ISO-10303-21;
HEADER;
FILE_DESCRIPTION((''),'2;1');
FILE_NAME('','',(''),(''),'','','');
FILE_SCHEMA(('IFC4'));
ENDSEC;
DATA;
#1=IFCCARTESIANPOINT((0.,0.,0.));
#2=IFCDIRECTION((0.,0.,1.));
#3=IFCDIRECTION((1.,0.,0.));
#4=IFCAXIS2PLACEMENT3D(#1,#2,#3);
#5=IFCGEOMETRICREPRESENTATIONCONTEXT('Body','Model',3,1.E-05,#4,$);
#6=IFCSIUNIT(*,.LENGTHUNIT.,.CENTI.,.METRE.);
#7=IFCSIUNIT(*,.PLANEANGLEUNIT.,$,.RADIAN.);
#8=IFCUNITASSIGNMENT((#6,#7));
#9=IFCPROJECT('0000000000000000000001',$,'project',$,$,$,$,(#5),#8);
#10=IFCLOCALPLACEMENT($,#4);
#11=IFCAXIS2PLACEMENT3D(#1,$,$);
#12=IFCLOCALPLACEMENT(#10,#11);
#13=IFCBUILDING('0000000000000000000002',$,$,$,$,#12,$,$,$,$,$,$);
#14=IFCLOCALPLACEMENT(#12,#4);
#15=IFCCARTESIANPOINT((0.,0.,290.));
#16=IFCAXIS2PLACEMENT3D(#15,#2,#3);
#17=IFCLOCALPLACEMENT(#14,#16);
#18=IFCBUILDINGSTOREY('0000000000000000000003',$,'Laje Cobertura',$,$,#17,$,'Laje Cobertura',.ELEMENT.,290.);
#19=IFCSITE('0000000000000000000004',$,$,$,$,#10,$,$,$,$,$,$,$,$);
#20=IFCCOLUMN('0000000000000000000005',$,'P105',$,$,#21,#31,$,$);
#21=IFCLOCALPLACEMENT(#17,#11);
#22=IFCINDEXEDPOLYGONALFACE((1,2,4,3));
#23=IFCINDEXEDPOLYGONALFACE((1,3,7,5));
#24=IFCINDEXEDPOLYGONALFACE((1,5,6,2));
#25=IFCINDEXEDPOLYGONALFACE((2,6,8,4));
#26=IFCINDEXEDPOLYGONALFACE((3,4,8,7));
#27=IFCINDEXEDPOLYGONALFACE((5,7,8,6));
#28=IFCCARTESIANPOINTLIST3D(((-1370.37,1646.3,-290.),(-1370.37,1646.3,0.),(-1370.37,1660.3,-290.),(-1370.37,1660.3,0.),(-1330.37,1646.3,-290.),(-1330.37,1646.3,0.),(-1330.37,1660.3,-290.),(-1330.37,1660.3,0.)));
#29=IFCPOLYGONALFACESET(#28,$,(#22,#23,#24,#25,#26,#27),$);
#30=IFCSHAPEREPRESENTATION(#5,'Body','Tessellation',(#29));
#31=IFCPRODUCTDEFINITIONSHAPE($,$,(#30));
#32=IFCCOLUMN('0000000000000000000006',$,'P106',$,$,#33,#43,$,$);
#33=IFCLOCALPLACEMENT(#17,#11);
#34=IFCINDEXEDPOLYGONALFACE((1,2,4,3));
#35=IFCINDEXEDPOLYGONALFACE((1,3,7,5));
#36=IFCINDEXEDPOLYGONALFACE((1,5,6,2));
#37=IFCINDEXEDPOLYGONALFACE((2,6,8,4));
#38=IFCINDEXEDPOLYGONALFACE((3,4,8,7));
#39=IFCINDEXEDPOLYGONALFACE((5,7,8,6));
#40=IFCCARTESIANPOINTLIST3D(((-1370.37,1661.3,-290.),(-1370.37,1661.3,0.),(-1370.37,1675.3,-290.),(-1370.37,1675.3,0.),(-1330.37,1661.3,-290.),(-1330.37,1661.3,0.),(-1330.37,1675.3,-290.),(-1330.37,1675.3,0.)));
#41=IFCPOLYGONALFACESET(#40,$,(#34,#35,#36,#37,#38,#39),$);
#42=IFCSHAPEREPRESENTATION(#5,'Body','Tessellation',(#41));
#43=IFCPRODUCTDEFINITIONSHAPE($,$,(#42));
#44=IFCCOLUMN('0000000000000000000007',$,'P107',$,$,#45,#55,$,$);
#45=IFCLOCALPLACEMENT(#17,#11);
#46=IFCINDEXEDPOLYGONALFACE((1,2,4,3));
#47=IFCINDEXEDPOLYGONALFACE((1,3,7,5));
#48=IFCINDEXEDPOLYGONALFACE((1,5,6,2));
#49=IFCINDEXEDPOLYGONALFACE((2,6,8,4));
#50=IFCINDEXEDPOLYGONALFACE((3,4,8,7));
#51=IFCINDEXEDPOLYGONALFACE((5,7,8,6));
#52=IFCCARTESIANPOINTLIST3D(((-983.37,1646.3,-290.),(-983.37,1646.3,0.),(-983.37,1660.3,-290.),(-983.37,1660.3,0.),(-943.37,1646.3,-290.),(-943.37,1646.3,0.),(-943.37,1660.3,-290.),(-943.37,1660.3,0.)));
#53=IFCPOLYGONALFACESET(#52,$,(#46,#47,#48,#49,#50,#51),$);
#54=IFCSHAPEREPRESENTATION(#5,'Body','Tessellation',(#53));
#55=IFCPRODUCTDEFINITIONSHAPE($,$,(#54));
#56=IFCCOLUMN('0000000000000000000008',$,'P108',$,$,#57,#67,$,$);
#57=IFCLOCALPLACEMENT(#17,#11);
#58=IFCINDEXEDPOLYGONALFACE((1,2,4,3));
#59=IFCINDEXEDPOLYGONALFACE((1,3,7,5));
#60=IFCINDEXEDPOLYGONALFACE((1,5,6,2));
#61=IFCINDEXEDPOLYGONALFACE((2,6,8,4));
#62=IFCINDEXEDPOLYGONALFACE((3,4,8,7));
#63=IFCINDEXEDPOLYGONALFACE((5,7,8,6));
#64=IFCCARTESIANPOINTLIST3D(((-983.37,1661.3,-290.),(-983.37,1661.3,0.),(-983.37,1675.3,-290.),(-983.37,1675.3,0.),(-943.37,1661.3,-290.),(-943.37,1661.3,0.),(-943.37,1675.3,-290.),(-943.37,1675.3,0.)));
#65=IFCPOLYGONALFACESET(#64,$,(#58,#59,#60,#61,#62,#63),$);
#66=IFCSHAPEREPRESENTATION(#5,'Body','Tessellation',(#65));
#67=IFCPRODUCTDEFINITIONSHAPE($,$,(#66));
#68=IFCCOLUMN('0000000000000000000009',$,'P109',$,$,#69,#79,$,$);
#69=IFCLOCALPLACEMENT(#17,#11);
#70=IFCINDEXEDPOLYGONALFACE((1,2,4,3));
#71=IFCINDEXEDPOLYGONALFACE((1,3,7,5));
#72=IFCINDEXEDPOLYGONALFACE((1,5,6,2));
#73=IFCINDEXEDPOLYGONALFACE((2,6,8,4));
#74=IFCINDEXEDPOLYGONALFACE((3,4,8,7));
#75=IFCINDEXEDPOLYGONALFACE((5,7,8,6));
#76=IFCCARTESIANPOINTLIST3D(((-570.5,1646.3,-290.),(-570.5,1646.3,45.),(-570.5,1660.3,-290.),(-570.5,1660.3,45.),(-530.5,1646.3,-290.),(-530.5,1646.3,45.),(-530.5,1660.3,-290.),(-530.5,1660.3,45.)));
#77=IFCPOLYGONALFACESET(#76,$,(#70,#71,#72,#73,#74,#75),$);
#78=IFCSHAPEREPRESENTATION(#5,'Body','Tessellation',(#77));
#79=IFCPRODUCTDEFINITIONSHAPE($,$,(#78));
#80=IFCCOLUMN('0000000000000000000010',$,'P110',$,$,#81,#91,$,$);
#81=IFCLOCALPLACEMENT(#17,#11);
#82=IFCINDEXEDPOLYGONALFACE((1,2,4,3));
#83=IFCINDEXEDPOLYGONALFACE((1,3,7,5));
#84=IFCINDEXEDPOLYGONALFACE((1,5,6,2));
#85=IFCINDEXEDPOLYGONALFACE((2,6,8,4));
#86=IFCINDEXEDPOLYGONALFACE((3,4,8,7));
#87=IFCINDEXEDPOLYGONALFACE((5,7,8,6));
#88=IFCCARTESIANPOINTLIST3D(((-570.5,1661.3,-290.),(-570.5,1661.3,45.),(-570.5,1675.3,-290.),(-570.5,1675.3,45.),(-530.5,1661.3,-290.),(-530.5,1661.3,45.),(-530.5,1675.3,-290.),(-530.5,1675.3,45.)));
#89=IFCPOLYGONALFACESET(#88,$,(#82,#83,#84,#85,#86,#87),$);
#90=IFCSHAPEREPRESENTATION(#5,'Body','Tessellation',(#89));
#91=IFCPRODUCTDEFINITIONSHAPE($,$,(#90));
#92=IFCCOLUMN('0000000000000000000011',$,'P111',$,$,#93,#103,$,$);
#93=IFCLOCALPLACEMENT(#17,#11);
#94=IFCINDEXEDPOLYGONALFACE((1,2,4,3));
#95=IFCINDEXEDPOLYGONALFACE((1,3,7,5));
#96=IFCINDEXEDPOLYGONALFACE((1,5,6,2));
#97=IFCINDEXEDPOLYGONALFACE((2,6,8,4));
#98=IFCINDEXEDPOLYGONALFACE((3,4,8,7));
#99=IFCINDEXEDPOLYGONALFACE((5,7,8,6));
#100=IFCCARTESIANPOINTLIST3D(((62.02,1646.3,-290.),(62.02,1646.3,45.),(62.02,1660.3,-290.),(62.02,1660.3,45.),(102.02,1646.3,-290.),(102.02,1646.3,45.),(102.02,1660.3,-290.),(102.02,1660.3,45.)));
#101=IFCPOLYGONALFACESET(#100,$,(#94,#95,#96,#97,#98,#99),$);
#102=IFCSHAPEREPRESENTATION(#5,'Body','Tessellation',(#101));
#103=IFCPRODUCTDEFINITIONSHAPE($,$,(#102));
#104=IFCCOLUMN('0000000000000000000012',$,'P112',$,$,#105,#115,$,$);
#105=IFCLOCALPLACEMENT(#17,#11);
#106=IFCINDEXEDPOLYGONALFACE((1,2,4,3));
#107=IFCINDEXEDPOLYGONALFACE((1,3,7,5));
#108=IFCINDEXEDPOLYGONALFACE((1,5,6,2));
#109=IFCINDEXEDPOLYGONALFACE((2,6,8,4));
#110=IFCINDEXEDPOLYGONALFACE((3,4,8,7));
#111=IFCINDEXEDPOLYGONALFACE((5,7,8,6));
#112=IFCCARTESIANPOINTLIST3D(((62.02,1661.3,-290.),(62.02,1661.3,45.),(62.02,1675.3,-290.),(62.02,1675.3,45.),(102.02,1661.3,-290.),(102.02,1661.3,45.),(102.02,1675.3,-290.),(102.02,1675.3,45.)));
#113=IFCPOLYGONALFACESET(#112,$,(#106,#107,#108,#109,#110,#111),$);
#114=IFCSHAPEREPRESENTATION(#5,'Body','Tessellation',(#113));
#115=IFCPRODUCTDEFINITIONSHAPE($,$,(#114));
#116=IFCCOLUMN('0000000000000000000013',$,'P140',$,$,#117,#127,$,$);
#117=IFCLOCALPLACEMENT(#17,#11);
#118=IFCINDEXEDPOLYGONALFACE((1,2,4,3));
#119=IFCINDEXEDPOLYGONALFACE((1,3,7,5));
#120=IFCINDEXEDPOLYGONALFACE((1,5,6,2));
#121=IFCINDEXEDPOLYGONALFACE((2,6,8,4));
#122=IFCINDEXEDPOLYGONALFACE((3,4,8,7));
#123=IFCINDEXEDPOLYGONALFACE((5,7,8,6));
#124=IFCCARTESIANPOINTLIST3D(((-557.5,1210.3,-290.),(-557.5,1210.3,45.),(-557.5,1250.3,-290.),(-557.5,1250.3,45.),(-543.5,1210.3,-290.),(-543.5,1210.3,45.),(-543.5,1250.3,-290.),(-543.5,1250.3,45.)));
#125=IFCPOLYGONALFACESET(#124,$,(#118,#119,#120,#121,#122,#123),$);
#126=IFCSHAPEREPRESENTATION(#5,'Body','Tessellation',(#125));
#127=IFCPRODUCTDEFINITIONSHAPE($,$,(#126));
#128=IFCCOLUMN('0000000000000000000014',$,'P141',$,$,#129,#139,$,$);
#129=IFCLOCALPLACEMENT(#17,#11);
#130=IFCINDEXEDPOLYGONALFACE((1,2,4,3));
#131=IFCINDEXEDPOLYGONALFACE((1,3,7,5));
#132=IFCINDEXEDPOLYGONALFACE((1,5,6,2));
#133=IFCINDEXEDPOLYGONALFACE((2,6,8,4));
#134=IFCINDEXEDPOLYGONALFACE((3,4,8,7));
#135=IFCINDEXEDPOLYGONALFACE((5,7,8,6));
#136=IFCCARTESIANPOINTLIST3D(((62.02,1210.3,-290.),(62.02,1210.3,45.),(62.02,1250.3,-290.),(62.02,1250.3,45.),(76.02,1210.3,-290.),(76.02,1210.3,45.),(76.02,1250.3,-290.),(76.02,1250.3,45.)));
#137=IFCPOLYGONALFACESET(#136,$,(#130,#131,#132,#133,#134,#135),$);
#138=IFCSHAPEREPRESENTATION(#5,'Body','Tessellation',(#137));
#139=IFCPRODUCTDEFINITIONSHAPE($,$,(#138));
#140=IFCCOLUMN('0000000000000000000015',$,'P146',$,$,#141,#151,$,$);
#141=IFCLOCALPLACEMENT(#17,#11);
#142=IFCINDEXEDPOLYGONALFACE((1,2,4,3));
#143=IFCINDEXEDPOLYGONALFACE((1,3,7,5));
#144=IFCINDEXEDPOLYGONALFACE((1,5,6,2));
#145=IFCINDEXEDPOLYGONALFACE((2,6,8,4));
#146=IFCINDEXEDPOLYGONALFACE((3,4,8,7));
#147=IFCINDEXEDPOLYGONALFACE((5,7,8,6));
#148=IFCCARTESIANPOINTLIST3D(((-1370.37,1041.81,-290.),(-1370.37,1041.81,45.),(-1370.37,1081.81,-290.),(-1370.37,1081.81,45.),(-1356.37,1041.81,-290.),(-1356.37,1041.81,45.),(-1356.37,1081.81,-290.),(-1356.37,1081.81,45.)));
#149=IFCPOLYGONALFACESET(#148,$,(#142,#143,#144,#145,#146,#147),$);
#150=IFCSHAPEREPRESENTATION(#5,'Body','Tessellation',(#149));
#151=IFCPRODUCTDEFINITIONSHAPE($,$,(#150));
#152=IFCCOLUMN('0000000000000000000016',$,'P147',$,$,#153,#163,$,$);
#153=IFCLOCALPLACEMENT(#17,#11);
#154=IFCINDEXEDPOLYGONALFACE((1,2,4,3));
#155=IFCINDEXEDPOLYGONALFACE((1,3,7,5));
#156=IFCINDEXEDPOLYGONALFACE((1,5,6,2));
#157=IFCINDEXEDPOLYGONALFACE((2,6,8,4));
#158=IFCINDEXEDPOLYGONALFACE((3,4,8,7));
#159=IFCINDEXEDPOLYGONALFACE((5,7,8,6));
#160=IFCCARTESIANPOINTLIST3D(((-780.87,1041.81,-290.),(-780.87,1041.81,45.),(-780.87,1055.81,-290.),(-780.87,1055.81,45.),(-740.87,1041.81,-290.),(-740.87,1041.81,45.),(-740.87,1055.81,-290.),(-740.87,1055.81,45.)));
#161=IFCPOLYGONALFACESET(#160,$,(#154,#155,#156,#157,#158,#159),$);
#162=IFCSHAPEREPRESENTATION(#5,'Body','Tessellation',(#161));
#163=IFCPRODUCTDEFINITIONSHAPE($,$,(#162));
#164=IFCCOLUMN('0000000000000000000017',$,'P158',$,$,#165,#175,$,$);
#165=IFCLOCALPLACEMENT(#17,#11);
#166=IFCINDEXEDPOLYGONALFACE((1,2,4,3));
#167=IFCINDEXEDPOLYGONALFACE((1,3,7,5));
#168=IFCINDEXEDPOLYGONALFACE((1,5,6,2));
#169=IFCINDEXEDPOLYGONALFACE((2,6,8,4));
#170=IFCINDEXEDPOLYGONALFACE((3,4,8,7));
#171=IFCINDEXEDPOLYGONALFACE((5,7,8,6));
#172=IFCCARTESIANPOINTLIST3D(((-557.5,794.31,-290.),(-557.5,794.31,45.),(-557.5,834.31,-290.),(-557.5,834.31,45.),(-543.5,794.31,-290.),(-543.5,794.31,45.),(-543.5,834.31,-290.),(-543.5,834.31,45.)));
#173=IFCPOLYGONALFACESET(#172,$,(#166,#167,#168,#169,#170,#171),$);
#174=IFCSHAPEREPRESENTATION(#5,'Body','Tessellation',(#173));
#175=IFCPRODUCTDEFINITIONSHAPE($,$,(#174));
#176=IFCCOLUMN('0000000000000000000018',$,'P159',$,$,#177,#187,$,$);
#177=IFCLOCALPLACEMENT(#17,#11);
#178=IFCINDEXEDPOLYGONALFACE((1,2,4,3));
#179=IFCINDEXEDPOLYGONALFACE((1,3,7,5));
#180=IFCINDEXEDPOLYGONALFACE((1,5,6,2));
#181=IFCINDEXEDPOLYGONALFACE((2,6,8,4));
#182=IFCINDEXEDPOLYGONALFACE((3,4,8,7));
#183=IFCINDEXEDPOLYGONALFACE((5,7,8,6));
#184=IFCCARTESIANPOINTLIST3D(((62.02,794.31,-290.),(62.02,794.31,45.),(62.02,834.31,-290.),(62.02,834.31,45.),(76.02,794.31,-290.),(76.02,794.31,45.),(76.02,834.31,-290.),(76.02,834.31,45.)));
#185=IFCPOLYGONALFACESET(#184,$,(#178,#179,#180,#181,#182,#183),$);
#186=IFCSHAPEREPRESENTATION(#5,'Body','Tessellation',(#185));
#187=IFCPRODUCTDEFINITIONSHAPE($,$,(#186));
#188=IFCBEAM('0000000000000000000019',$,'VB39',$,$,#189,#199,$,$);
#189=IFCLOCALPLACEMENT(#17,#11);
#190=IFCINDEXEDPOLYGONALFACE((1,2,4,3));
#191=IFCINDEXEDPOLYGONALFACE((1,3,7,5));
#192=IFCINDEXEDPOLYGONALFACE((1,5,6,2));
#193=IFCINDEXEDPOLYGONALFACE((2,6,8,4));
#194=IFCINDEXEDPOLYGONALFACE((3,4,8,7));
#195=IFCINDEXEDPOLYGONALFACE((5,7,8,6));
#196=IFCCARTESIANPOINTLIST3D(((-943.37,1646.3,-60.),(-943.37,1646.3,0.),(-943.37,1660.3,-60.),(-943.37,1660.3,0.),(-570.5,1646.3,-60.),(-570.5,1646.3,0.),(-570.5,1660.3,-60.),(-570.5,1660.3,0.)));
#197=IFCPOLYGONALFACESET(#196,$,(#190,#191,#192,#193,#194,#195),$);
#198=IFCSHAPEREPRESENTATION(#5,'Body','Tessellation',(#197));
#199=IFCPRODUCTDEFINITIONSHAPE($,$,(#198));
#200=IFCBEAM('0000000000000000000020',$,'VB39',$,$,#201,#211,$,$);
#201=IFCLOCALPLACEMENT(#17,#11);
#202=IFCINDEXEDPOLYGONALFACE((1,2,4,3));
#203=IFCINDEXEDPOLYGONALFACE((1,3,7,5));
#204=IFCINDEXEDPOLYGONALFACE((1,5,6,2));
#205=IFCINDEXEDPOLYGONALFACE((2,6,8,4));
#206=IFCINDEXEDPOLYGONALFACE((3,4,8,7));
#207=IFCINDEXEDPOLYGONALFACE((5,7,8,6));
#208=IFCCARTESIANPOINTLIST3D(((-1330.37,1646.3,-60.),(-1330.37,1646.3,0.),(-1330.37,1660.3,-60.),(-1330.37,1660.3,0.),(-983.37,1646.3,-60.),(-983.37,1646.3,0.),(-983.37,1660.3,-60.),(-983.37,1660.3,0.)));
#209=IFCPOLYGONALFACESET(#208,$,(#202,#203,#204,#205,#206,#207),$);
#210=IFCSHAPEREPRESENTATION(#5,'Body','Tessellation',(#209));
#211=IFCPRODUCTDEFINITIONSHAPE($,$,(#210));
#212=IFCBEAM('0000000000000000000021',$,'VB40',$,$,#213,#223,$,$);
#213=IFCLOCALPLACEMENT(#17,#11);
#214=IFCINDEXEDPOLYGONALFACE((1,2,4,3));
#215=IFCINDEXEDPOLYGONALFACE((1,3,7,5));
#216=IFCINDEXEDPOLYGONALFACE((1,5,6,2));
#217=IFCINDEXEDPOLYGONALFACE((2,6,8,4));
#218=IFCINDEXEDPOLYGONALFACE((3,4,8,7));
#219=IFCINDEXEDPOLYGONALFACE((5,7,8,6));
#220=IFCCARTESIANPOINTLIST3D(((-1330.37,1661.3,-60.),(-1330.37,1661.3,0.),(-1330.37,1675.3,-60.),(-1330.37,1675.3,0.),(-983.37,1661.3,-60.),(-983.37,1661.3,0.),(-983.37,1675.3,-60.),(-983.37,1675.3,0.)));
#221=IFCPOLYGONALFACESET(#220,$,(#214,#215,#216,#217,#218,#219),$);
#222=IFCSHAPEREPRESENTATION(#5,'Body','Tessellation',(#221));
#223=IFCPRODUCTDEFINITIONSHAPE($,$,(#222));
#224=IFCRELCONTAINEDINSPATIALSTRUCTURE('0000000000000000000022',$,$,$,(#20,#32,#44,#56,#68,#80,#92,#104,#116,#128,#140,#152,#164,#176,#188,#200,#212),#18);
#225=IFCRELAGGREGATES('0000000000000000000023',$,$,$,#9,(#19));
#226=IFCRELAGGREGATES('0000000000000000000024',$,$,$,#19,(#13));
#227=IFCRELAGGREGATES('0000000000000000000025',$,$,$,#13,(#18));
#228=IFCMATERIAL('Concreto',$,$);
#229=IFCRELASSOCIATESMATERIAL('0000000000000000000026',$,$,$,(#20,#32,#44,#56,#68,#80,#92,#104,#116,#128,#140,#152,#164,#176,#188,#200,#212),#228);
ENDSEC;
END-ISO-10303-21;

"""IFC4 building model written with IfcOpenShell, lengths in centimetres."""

from ifc_helpers import new_model, si_unit, frame, origin, origin_with_axes, origin_2d_with_axis, place, context, project, spatial, rectangle, extrude, material, element, save


model = new_model("IFC4")

# Units and contexts
model_context = context("Model", 3, precision=1e-05, world=origin_with_axes(), identifier="Body")
ifc_project = project(units=[si_unit("LENGTHUNIT", "METRE", prefix="CENTI"), si_unit("PLANEANGLEUNIT", "RADIAN")], contexts=[model_context])

# Site, building, storey
site_placement = place(None, origin_with_axes())
site = spatial("IfcSite", under=ifc_project, at=site_placement)
building_placement = place(site_placement, origin())
building = spatial("IfcBuilding", under=site, at=building_placement)
placement = place(building_placement, origin_with_axes())
storey_placement = place(placement, frame((0.0, 0.0, 290.0), z_axis=(0.0, 0.0, 1.0), x_axis=(1.0, 0.0, 0.0)))
storey = spatial("IfcBuildingStorey", under=building, at=storey_placement, Name="Laje Cobertura", LongName="Laje Cobertura", CompositionType="ELEMENT", Elevation=290.0)

# Columns
ifc_material = material(Name="Concreto")
for number, where, z_axis, x_axis, name in (
    (1, (-1350.37, 1653.3, 0.0), (0.0, 0.0, 1.0), (1.0, 0.0, 0.0), "P105"),
    (2, (-1350.37, 1668.3, 0.0), (0.0, 0.0, 1.0), (1.0, 0.0, 0.0), "P106"),
    (3, (-963.37, 1653.3, 0.0), (0.0, 0.0, 1.0), (1.0, 0.0, 0.0), "P107"),
    (4, (-963.37, 1668.3, 0.0), (0.0, 0.0, 1.0), (1.0, 0.0, 0.0), "P108"),
):
    element("IfcColumn", number, at=place(storey_placement, frame(where, z_axis=z_axis, x_axis=x_axis)), inside=storey, material=ifc_material, Name=name, context=model_context, shape_type="SolidModel", body=[
        extrude(rectangle(XDim=14.0, YDim=40.0, at=origin_2d_with_axis()), frame((0.0, 0.0, 0.0), z_axis=(0.0, 0.0, 1.0), x_axis=(0.0, -1.0, 0.0)), (0.0, 0.0, -1.0), 290.0),
    ])
for number, where, z_axis, x_axis, name in (
    (5, (-550.5, 1653.3, 45.0), (0.0, 0.0, 1.0), (1.0, 0.0, 0.0), "P109"),
    (6, (-550.5, 1668.3, 45.0), (0.0, 0.0, 1.0), (1.0, 0.0, 0.0), "P110"),
    (7, (82.02, 1653.3, 45.0), (0.0, 0.0, 1.0), (1.0, 0.0, 0.0), "P111"),
    (8, (82.02, 1668.3, 45.0), (0.0, 0.0, 1.0), (1.0, 0.0, 0.0), "P112"),
):
    element("IfcColumn", number, at=place(storey_placement, frame(where, z_axis=z_axis, x_axis=x_axis)), inside=storey, material=ifc_material, Name=name, context=model_context, shape_type="SolidModel", body=[
        extrude(rectangle(XDim=14.0, YDim=40.0, at=origin_2d_with_axis()), frame((0.0, 0.0, 0.0), z_axis=(0.0, 0.0, 1.0), x_axis=(0.0, -1.0, 0.0)), (0.0, 0.0, -1.0), 335.0),
    ])
for number, where, z_axis, x_axis, name in (
    (9, (-550.5, 1230.3, 45.0), (0.0, 0.0, 1.0), (1.0, 0.0, 0.0), "P140"),
    (10, (69.02, 1230.3, 45.0), (0.0, 0.0, 1.0), (1.0, 0.0, 0.0), "P141"),
    (11, (-1363.37, 1061.81, 45.0), (0.0, 0.0, 1.0), (1.0, 0.0, 0.0), "P146"),
):
    element("IfcColumn", number, at=place(storey_placement, frame(where, z_axis=z_axis, x_axis=x_axis)), inside=storey, material=ifc_material, Name=name, context=model_context, shape_type="SolidModel", body=[
        extrude(rectangle(XDim=14.0, YDim=40.0, at=origin_2d_with_axis()), origin_with_axes(), (0.0, 0.0, -1.0), 335.0),
    ])
column_placement = place(storey_placement, frame((-760.87, 1048.81, 45.0), z_axis=(0.0, 0.0, 1.0), x_axis=(1.0, 0.0, 0.0)))
element("IfcColumn", 12, at=column_placement, inside=storey, material=ifc_material, Name="P147", context=model_context, shape_type="SolidModel", body=[
    extrude(rectangle(XDim=14.0, YDim=40.0, at=origin_2d_with_axis()), frame((0.0, 0.0, 0.0), z_axis=(0.0, 0.0, 1.0), x_axis=(0.0, 1.0, 0.0)), (0.0, 0.0, -1.0), 335.0),
])
for number, where, z_axis, x_axis, name in (
    (13, (-550.5, 814.31, 45.0), (0.0, 0.0, 1.0), (1.0, 0.0, 0.0), "P158"),
    (14, (69.02, 814.31, 45.0), (0.0, 0.0, 1.0), (1.0, 0.0, 0.0), "P159"),
):
    element("IfcColumn", number, at=place(storey_placement, frame(where, z_axis=z_axis, x_axis=x_axis)), inside=storey, material=ifc_material, Name=name, context=model_context, shape_type="SolidModel", body=[
        extrude(rectangle(XDim=14.0, YDim=40.0, at=origin_2d_with_axis()), origin_with_axes(), (0.0, 0.0, -1.0), 335.0),
    ])

# Beams
beam_1_placement = place(storey_placement, frame((-756.93, 1653.3, 0.0), z_axis=(0.0, 0.0, 1.0), x_axis=(1.0, 0.0, 0.0)))
element("IfcBeam", 15, at=beam_1_placement, inside=storey, material=ifc_material, Name="VB39", context=model_context, shape_type="SolidModel", body=[
    extrude(rectangle(XDim=14.0, YDim=60.0, at=origin_2d_with_axis()), frame((-186.44, 0.0, -30.0), z_axis=(1.0, 0.0, 0.0), x_axis=(0.0, 1.0, 0.0)), (0.0, 0.0, 1.0), 372.87),
])
for number, where, z_axis, x_axis, name in (
    (16, (-1156.87, 1653.3, 0.0), (0.0, 0.0, 1.0), (1.0, 0.0, 0.0), "VB39"),
    (17, (-1156.87, 1668.3, 0.0), (0.0, 0.0, 1.0), (1.0, 0.0, 0.0), "VB40"),
):
    element("IfcBeam", number, at=place(storey_placement, frame(where, z_axis=z_axis, x_axis=x_axis)), inside=storey, material=ifc_material, Name=name, context=model_context, shape_type="SolidModel", body=[
        extrude(rectangle(XDim=14.0, YDim=60.0, at=origin_2d_with_axis()), frame((-173.5, 0.0, -30.0), z_axis=(1.0, 0.0, 0.0), x_axis=(0.0, 1.0, 0.0)), (0.0, 0.0, 1.0), 347.0),
    ])

save(model, "model.ifc")
